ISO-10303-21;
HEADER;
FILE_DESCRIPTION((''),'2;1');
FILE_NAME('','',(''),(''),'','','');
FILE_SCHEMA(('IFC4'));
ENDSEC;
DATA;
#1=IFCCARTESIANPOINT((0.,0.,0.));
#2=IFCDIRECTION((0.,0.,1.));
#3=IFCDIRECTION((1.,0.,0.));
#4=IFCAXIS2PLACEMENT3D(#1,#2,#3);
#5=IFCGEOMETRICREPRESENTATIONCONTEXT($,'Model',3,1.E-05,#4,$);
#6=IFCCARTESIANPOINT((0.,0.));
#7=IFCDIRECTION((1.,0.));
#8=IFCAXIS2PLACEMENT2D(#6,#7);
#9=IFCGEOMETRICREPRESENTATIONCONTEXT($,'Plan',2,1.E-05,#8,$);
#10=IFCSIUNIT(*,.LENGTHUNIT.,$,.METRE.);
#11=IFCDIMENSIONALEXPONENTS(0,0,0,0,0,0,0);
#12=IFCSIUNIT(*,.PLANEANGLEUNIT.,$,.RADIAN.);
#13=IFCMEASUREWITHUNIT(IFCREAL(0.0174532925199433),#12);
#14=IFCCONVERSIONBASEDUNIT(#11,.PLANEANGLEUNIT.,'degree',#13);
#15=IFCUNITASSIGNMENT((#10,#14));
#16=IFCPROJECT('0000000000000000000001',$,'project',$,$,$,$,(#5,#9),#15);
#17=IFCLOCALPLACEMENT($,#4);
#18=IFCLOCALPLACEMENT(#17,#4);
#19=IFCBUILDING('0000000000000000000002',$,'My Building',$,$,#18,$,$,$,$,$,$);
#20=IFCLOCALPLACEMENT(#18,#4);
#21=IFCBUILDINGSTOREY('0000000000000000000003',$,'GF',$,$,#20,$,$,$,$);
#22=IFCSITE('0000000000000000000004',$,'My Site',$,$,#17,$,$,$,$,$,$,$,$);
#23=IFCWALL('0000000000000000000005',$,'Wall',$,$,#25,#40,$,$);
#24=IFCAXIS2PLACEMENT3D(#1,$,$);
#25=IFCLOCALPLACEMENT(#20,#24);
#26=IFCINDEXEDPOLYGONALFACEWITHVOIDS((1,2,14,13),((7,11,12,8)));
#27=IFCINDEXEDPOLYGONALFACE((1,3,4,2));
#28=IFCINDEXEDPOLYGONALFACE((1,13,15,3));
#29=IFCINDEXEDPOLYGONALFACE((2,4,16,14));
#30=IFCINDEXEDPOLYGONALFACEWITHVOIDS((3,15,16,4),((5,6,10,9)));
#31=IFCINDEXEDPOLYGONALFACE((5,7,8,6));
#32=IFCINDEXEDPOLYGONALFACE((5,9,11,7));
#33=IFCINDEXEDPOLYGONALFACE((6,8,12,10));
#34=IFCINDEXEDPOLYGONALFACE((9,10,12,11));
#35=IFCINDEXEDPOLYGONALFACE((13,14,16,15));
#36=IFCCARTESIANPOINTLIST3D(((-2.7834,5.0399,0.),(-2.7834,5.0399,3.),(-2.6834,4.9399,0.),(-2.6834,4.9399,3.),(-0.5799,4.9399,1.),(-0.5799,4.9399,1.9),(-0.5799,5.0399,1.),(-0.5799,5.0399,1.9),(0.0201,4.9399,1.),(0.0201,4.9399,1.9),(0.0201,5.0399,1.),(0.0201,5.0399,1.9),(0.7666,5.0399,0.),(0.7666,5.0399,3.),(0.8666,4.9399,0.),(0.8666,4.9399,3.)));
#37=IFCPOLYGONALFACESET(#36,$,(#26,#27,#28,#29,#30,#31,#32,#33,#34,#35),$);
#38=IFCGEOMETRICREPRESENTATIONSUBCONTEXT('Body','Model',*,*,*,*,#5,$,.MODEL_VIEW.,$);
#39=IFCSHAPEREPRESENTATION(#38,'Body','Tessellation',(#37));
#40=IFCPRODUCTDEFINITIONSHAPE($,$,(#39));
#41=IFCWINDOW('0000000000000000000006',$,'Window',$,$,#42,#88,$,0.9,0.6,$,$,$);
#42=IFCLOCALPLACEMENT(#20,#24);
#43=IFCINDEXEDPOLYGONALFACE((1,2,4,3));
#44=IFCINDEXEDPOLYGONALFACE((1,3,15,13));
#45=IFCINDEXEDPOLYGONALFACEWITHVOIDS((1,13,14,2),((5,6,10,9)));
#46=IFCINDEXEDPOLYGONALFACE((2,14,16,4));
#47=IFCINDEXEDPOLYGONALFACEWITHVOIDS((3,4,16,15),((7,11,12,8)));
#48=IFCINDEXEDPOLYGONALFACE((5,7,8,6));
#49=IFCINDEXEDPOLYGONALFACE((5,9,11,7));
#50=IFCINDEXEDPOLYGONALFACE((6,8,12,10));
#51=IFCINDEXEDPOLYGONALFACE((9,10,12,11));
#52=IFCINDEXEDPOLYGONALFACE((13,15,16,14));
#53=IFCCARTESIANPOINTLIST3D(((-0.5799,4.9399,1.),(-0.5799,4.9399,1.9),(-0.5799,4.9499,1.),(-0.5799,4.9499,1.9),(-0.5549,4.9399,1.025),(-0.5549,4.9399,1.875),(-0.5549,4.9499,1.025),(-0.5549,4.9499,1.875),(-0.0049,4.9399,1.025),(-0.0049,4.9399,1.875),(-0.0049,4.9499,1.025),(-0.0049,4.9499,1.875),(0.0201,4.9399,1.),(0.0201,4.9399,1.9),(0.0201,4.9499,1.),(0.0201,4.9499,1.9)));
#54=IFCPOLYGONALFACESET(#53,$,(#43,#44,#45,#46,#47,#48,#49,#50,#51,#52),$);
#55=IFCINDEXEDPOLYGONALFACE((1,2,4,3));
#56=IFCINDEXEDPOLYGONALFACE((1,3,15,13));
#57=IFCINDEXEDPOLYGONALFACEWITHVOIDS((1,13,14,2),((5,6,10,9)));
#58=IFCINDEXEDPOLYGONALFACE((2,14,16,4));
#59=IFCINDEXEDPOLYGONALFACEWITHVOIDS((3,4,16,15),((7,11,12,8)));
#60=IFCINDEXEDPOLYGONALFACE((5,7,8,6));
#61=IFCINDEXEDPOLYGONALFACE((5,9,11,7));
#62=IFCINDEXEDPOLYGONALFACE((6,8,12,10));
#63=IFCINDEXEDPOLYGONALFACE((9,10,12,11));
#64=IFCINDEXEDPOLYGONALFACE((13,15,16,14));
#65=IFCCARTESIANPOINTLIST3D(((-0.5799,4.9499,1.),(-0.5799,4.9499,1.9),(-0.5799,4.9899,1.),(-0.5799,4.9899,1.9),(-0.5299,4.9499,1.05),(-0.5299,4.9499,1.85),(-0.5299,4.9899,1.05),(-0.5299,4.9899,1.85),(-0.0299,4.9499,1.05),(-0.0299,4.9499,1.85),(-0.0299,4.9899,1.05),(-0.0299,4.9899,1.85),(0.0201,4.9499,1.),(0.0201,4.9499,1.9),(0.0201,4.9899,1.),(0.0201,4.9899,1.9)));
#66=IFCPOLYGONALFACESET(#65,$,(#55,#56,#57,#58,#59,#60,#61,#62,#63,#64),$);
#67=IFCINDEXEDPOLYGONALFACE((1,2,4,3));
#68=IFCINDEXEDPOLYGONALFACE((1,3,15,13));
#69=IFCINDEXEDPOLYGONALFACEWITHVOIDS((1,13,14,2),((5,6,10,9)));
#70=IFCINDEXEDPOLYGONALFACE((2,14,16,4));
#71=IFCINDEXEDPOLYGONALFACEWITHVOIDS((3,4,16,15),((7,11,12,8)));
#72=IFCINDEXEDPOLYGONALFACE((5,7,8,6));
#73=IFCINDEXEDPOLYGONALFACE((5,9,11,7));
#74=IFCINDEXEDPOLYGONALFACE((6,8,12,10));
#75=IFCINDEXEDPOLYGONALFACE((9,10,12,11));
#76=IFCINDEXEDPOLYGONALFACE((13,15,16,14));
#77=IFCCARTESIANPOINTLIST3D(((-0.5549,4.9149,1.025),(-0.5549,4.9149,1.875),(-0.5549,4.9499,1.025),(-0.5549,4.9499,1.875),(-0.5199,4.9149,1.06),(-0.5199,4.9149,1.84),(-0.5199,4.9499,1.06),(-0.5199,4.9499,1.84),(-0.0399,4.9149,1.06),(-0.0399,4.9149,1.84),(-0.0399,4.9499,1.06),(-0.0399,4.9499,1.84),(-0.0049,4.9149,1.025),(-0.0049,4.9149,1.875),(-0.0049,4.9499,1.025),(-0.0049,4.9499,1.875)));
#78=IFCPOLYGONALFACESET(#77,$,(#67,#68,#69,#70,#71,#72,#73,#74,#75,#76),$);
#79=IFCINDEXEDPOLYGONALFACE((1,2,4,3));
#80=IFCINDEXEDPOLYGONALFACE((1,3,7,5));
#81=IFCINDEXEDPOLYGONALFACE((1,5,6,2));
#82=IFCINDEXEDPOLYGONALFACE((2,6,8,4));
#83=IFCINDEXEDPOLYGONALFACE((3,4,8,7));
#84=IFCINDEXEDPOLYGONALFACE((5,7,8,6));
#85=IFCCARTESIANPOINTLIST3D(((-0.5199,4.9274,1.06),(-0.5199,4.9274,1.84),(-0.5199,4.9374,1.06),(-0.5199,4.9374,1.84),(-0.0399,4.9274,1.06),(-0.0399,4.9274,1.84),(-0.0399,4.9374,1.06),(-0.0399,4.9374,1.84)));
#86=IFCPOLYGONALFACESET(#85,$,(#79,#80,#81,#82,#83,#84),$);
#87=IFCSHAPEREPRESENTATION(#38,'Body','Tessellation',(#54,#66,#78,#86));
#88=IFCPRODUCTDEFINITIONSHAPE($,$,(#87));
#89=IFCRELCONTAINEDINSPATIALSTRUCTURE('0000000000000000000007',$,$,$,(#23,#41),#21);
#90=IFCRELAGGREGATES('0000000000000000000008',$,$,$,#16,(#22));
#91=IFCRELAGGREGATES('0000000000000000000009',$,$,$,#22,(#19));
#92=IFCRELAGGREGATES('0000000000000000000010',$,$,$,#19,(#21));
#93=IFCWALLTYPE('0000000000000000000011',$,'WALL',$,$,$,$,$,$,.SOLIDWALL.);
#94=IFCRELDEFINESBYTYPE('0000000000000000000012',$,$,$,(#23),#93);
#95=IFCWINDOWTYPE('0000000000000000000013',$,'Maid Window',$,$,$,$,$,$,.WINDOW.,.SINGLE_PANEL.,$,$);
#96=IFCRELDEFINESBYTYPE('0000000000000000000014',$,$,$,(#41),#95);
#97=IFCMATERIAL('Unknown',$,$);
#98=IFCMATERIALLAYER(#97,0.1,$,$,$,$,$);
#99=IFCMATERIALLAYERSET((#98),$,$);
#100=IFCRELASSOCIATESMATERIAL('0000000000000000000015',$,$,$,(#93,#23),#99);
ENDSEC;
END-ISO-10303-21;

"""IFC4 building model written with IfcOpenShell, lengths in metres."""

from ifc_helpers import new_model, entity, si_unit, converted_unit, frame, origin_with_axes, origin_2d_with_axis, place, context, subcontext, project, spatial, line, indexed_curve, outline, extrude, shape, source, transform, mapped, material, layer, layer_set, layer_usage, type_object, type_shapes, element, fill, save


model = new_model("IFC4")

# Units and contexts
model_context = context("Model", 3, precision=1e-05, world=origin_with_axes())
plan_context = context("Plan", 2, precision=1e-05, world=origin_2d_with_axis())
body_context_1 = subcontext(model_context, "Body", "Model", "MODEL_VIEW")
body_context_2 = subcontext(plan_context, "Body", "Plan", "PLAN_VIEW")
ifc_project = project(units=[si_unit("LENGTHUNIT", "METRE"), converted_unit("PLANEANGLEUNIT", "degree", entity("IfcReal", 0.0174532925199433), si_unit("PLANEANGLEUNIT", "RADIAN"), dimensions=[0, 0, 0, 0, 0, 0, 0])], contexts=[model_context, plan_context])

# Site, building, storey
site_placement = place(None, origin_with_axes())
site = spatial("IfcSite", under=ifc_project, at=site_placement, Name="My Site")
building_placement = place(site_placement, origin_with_axes())
building = spatial("IfcBuilding", under=site, at=building_placement, Name="My Building")
storey_placement = place(building_placement, origin_with_axes())
storey = spatial("IfcBuildingStorey", under=building, at=storey_placement, Name="GF")

# Shared definitions
ifc_material = material(Name="Unknown")

# Shared definitions
ifc_layer = layer(ifc_material, 0.1)
ifc_layer_set = layer_set([ifc_layer])
wall_type = type_object("IfcWallType", Name="WALL", PredefinedType="SOLIDWALL", material=ifc_layer_set)

# Wall, opening, window
ifc_layer_usage_1 = layer_usage(ifc_layer_set, "AXIS2", "POSITIVE", 0.0)
wall_1_placement = place(storey_placement, frame((0.7666, 5.0399, 0.0), z_axis=(0.0, 0.0, 1.0), x_axis=(-1.0, 0.0, 0.0)))
wall_1 = element("IfcWall", 1, at=wall_1_placement, inside=storey, type_object=wall_type, material=ifc_layer_usage_1, Name="Wall", context=body_context_1, shape_type="SweptSolid", body=[
    extrude(outline(indexed_curve([(0.0, 0.0), (-0.1, 0.1), (3.45, 0.1), (3.55, 0.0)], segments=[line(1, 2, 3, 4, 1)])), origin_with_axes(), (0.0, 0.0, 1.0), 3.0),
])
shared_shape_1 = source(origin_with_axes(), body_context_1, "Body", "SweptSolid", [
    extrude(outline(indexed_curve([(0.0, 0.0), (0.6, 0.0), (0.6, 0.9), (0.0, 0.9)], segments=[line(1, 2, 3, 4, 1)])), frame((0.0, -0.6, 0.0), z_axis=(0.0, -1.0, 0.0), x_axis=(1.0, 0.0, 0.0)), (0.0, 0.0, -1.0), 1.2),
])
opening_1_placement = place(wall_1_placement, frame((0.7465, 0.0, 1.0), z_axis=(0.0, 0.0, 1.0), x_axis=(1.0, 0.0, 0.0)))
opening_1 = element("IfcOpeningElement", 2, at=opening_1_placement, cuts=wall_1, PredefinedType="OPENING", context=body_context_1, shape_type="MappedRepresentation", body=[
    mapped(shared_shape_1, transform((0.0, 0.0, 0.0), x_axis=(1.0, 0.0, 0.0), y_axis=(0.0, 1.0, 0.0), z_axis=(0.0, 0.0, 1.0), scale=1.0)),
])
window_type_1 = type_object("IfcWindowType", Name="Maid Window", PartitioningType="SINGLE_PANEL", PredefinedType="WINDOW")
shared_shape_2 = source(origin_with_axes(), body_context_1, "Body", "SweptSolid", [
    extrude(outline(indexed_curve([(0.0, 0.0), (0.6, 0.0), (0.6, 0.9), (0.0, 0.9)], segments=[line(1, 2, 3, 4, 1)]), holes=[indexed_curve([(0.025, 0.025), (0.575, 0.025), (0.575, 0.875), (0.025, 0.875)], segments=[line(1, 2, 3, 4, 1)])]), frame((0.0, 0.09, 0.0), z_axis=(0.0, -1.0, 0.0), x_axis=(1.0, 0.0, 0.0)), (0.0, 0.0, -1.0), 0.01),
    extrude(outline(indexed_curve([(0.0, 0.0), (0.6, 0.0), (0.6, 0.9), (0.0, 0.9)], segments=[line(1, 2, 3, 4, 1)]), holes=[indexed_curve([(0.05, 0.05), (0.55, 0.05), (0.55, 0.85), (0.05, 0.85)], segments=[line(1, 2, 3, 4, 1)])]), frame((0.0, 0.05, 0.0), z_axis=(0.0, -1.0, 0.0), x_axis=(1.0, 0.0, 0.0)), (0.0, 0.0, -1.0), 0.04),
    extrude(outline(indexed_curve([(0.0, 0.0), (0.55, 0.0), (0.55, 0.85), (0.0, 0.85)], segments=[line(1, 2, 3, 4, 1)]), holes=[indexed_curve([(0.035, 0.035), (0.515, 0.035), (0.515, 0.815), (0.035, 0.815)], segments=[line(1, 2, 3, 4, 1)])]), frame((0.025, 0.09, 0.025), z_axis=(0.0, -1.0, 0.0), x_axis=(1.0, 0.0, 0.0)), (0.0, 0.0, -1.0), 0.035),
    extrude(outline(indexed_curve([(0.035, 0.035), (0.515, 0.035), (0.515, 0.815), (0.035, 0.815)], segments=[line(1, 2, 3, 4, 1)])), frame((0.025, 0.1025, 0.025), z_axis=(0.0, -1.0, 0.0), x_axis=(1.0, 0.0, 0.0)), (0.0, 0.0, -1.0), 0.01),
])
shared_shape_3 = source(origin_with_axes(), body_context_2, "Body", "Curve2D", [
    entity("IfcIndexedPolyCurve", entity("IfcCartesianPointList2D", [[0.05, 0.05], [0.55, 0.05]])),
    entity("IfcIndexedPolyCurve", entity("IfcCartesianPointList2D", [[0.0, 0.1], [0.025, 0.1], [0.025, 0.09], [0.05, 0.09], [0.05, 0.05], [0.0, 0.05]]), [entity("IfcLineIndex", [1, 2, 3, 4, 5, 6, 1])]),
    entity("IfcIndexedPolyCurve", entity("IfcCartesianPointList2D", [[0.6, 0.1], [0.575, 0.1], [0.575, 0.09], [0.55, 0.09], [0.55, 0.05], [0.6, 0.05]]), [entity("IfcLineIndex", [1, 2, 3, 4, 5, 6, 1])]),
    entity("IfcIndexedPolyCurve", entity("IfcCartesianPointList2D", [[0.025, 0.09], [0.06, 0.09], [0.06, 0.125], [0.025, 0.125]]), [entity("IfcLineIndex", [1, 2, 3, 4, 1])]),
    entity("IfcIndexedPolyCurve", entity("IfcCartesianPointList2D", [[0.575, 0.09], [0.54, 0.09], [0.54, 0.125], [0.575, 0.125]]), [entity("IfcLineIndex", [1, 2, 3, 4, 1])]),
    entity("IfcIndexedPolyCurve", entity("IfcCartesianPointList2D", [[0.06, 0.09], [0.54, 0.09]])),
    entity("IfcIndexedPolyCurve", entity("IfcCartesianPointList2D", [[0.06, 0.125], [0.54, 0.125]])),
    entity("IfcIndexedPolyCurve", entity("IfcCartesianPointList2D", [[0.06, 0.1075], [0.54, 0.1075]])),
])
type_shapes(window_type_1, [shared_shape_2, shared_shape_3])
window_1_placement = place(opening_1_placement, frame((0.0, 0.0, 0.0), z_axis=(0.0, 0.0, 1.0), x_axis=(1.0, 0.0, 0.0)))
window_1 = element("IfcWindow", 3, at=window_1_placement, inside=storey, type_object=window_type_1, Name="Window", OverallHeight=0.9, OverallWidth=0.6, shapes=[
    shape(body_context_1, "Body", "MappedRepresentation", [mapped(shared_shape_2, transform((0.0, 0.0, 0.0), x_axis=(1.0, 0.0, 0.0), y_axis=(0.0, 1.0, 0.0), z_axis=(0.0, 0.0, 1.0), scale=1.0))]),
    shape(body_context_2, "Body", "MappedRepresentation", [mapped(shared_shape_3, transform((0.0, 0.0, 0.0), x_axis=(1.0, 0.0, 0.0), y_axis=(0.0, 1.0, 0.0), z_axis=(0.0, 0.0, 1.0), scale=1.0))]),
])
fill(opening_1, window_1)

save(model, "model.ifc")
